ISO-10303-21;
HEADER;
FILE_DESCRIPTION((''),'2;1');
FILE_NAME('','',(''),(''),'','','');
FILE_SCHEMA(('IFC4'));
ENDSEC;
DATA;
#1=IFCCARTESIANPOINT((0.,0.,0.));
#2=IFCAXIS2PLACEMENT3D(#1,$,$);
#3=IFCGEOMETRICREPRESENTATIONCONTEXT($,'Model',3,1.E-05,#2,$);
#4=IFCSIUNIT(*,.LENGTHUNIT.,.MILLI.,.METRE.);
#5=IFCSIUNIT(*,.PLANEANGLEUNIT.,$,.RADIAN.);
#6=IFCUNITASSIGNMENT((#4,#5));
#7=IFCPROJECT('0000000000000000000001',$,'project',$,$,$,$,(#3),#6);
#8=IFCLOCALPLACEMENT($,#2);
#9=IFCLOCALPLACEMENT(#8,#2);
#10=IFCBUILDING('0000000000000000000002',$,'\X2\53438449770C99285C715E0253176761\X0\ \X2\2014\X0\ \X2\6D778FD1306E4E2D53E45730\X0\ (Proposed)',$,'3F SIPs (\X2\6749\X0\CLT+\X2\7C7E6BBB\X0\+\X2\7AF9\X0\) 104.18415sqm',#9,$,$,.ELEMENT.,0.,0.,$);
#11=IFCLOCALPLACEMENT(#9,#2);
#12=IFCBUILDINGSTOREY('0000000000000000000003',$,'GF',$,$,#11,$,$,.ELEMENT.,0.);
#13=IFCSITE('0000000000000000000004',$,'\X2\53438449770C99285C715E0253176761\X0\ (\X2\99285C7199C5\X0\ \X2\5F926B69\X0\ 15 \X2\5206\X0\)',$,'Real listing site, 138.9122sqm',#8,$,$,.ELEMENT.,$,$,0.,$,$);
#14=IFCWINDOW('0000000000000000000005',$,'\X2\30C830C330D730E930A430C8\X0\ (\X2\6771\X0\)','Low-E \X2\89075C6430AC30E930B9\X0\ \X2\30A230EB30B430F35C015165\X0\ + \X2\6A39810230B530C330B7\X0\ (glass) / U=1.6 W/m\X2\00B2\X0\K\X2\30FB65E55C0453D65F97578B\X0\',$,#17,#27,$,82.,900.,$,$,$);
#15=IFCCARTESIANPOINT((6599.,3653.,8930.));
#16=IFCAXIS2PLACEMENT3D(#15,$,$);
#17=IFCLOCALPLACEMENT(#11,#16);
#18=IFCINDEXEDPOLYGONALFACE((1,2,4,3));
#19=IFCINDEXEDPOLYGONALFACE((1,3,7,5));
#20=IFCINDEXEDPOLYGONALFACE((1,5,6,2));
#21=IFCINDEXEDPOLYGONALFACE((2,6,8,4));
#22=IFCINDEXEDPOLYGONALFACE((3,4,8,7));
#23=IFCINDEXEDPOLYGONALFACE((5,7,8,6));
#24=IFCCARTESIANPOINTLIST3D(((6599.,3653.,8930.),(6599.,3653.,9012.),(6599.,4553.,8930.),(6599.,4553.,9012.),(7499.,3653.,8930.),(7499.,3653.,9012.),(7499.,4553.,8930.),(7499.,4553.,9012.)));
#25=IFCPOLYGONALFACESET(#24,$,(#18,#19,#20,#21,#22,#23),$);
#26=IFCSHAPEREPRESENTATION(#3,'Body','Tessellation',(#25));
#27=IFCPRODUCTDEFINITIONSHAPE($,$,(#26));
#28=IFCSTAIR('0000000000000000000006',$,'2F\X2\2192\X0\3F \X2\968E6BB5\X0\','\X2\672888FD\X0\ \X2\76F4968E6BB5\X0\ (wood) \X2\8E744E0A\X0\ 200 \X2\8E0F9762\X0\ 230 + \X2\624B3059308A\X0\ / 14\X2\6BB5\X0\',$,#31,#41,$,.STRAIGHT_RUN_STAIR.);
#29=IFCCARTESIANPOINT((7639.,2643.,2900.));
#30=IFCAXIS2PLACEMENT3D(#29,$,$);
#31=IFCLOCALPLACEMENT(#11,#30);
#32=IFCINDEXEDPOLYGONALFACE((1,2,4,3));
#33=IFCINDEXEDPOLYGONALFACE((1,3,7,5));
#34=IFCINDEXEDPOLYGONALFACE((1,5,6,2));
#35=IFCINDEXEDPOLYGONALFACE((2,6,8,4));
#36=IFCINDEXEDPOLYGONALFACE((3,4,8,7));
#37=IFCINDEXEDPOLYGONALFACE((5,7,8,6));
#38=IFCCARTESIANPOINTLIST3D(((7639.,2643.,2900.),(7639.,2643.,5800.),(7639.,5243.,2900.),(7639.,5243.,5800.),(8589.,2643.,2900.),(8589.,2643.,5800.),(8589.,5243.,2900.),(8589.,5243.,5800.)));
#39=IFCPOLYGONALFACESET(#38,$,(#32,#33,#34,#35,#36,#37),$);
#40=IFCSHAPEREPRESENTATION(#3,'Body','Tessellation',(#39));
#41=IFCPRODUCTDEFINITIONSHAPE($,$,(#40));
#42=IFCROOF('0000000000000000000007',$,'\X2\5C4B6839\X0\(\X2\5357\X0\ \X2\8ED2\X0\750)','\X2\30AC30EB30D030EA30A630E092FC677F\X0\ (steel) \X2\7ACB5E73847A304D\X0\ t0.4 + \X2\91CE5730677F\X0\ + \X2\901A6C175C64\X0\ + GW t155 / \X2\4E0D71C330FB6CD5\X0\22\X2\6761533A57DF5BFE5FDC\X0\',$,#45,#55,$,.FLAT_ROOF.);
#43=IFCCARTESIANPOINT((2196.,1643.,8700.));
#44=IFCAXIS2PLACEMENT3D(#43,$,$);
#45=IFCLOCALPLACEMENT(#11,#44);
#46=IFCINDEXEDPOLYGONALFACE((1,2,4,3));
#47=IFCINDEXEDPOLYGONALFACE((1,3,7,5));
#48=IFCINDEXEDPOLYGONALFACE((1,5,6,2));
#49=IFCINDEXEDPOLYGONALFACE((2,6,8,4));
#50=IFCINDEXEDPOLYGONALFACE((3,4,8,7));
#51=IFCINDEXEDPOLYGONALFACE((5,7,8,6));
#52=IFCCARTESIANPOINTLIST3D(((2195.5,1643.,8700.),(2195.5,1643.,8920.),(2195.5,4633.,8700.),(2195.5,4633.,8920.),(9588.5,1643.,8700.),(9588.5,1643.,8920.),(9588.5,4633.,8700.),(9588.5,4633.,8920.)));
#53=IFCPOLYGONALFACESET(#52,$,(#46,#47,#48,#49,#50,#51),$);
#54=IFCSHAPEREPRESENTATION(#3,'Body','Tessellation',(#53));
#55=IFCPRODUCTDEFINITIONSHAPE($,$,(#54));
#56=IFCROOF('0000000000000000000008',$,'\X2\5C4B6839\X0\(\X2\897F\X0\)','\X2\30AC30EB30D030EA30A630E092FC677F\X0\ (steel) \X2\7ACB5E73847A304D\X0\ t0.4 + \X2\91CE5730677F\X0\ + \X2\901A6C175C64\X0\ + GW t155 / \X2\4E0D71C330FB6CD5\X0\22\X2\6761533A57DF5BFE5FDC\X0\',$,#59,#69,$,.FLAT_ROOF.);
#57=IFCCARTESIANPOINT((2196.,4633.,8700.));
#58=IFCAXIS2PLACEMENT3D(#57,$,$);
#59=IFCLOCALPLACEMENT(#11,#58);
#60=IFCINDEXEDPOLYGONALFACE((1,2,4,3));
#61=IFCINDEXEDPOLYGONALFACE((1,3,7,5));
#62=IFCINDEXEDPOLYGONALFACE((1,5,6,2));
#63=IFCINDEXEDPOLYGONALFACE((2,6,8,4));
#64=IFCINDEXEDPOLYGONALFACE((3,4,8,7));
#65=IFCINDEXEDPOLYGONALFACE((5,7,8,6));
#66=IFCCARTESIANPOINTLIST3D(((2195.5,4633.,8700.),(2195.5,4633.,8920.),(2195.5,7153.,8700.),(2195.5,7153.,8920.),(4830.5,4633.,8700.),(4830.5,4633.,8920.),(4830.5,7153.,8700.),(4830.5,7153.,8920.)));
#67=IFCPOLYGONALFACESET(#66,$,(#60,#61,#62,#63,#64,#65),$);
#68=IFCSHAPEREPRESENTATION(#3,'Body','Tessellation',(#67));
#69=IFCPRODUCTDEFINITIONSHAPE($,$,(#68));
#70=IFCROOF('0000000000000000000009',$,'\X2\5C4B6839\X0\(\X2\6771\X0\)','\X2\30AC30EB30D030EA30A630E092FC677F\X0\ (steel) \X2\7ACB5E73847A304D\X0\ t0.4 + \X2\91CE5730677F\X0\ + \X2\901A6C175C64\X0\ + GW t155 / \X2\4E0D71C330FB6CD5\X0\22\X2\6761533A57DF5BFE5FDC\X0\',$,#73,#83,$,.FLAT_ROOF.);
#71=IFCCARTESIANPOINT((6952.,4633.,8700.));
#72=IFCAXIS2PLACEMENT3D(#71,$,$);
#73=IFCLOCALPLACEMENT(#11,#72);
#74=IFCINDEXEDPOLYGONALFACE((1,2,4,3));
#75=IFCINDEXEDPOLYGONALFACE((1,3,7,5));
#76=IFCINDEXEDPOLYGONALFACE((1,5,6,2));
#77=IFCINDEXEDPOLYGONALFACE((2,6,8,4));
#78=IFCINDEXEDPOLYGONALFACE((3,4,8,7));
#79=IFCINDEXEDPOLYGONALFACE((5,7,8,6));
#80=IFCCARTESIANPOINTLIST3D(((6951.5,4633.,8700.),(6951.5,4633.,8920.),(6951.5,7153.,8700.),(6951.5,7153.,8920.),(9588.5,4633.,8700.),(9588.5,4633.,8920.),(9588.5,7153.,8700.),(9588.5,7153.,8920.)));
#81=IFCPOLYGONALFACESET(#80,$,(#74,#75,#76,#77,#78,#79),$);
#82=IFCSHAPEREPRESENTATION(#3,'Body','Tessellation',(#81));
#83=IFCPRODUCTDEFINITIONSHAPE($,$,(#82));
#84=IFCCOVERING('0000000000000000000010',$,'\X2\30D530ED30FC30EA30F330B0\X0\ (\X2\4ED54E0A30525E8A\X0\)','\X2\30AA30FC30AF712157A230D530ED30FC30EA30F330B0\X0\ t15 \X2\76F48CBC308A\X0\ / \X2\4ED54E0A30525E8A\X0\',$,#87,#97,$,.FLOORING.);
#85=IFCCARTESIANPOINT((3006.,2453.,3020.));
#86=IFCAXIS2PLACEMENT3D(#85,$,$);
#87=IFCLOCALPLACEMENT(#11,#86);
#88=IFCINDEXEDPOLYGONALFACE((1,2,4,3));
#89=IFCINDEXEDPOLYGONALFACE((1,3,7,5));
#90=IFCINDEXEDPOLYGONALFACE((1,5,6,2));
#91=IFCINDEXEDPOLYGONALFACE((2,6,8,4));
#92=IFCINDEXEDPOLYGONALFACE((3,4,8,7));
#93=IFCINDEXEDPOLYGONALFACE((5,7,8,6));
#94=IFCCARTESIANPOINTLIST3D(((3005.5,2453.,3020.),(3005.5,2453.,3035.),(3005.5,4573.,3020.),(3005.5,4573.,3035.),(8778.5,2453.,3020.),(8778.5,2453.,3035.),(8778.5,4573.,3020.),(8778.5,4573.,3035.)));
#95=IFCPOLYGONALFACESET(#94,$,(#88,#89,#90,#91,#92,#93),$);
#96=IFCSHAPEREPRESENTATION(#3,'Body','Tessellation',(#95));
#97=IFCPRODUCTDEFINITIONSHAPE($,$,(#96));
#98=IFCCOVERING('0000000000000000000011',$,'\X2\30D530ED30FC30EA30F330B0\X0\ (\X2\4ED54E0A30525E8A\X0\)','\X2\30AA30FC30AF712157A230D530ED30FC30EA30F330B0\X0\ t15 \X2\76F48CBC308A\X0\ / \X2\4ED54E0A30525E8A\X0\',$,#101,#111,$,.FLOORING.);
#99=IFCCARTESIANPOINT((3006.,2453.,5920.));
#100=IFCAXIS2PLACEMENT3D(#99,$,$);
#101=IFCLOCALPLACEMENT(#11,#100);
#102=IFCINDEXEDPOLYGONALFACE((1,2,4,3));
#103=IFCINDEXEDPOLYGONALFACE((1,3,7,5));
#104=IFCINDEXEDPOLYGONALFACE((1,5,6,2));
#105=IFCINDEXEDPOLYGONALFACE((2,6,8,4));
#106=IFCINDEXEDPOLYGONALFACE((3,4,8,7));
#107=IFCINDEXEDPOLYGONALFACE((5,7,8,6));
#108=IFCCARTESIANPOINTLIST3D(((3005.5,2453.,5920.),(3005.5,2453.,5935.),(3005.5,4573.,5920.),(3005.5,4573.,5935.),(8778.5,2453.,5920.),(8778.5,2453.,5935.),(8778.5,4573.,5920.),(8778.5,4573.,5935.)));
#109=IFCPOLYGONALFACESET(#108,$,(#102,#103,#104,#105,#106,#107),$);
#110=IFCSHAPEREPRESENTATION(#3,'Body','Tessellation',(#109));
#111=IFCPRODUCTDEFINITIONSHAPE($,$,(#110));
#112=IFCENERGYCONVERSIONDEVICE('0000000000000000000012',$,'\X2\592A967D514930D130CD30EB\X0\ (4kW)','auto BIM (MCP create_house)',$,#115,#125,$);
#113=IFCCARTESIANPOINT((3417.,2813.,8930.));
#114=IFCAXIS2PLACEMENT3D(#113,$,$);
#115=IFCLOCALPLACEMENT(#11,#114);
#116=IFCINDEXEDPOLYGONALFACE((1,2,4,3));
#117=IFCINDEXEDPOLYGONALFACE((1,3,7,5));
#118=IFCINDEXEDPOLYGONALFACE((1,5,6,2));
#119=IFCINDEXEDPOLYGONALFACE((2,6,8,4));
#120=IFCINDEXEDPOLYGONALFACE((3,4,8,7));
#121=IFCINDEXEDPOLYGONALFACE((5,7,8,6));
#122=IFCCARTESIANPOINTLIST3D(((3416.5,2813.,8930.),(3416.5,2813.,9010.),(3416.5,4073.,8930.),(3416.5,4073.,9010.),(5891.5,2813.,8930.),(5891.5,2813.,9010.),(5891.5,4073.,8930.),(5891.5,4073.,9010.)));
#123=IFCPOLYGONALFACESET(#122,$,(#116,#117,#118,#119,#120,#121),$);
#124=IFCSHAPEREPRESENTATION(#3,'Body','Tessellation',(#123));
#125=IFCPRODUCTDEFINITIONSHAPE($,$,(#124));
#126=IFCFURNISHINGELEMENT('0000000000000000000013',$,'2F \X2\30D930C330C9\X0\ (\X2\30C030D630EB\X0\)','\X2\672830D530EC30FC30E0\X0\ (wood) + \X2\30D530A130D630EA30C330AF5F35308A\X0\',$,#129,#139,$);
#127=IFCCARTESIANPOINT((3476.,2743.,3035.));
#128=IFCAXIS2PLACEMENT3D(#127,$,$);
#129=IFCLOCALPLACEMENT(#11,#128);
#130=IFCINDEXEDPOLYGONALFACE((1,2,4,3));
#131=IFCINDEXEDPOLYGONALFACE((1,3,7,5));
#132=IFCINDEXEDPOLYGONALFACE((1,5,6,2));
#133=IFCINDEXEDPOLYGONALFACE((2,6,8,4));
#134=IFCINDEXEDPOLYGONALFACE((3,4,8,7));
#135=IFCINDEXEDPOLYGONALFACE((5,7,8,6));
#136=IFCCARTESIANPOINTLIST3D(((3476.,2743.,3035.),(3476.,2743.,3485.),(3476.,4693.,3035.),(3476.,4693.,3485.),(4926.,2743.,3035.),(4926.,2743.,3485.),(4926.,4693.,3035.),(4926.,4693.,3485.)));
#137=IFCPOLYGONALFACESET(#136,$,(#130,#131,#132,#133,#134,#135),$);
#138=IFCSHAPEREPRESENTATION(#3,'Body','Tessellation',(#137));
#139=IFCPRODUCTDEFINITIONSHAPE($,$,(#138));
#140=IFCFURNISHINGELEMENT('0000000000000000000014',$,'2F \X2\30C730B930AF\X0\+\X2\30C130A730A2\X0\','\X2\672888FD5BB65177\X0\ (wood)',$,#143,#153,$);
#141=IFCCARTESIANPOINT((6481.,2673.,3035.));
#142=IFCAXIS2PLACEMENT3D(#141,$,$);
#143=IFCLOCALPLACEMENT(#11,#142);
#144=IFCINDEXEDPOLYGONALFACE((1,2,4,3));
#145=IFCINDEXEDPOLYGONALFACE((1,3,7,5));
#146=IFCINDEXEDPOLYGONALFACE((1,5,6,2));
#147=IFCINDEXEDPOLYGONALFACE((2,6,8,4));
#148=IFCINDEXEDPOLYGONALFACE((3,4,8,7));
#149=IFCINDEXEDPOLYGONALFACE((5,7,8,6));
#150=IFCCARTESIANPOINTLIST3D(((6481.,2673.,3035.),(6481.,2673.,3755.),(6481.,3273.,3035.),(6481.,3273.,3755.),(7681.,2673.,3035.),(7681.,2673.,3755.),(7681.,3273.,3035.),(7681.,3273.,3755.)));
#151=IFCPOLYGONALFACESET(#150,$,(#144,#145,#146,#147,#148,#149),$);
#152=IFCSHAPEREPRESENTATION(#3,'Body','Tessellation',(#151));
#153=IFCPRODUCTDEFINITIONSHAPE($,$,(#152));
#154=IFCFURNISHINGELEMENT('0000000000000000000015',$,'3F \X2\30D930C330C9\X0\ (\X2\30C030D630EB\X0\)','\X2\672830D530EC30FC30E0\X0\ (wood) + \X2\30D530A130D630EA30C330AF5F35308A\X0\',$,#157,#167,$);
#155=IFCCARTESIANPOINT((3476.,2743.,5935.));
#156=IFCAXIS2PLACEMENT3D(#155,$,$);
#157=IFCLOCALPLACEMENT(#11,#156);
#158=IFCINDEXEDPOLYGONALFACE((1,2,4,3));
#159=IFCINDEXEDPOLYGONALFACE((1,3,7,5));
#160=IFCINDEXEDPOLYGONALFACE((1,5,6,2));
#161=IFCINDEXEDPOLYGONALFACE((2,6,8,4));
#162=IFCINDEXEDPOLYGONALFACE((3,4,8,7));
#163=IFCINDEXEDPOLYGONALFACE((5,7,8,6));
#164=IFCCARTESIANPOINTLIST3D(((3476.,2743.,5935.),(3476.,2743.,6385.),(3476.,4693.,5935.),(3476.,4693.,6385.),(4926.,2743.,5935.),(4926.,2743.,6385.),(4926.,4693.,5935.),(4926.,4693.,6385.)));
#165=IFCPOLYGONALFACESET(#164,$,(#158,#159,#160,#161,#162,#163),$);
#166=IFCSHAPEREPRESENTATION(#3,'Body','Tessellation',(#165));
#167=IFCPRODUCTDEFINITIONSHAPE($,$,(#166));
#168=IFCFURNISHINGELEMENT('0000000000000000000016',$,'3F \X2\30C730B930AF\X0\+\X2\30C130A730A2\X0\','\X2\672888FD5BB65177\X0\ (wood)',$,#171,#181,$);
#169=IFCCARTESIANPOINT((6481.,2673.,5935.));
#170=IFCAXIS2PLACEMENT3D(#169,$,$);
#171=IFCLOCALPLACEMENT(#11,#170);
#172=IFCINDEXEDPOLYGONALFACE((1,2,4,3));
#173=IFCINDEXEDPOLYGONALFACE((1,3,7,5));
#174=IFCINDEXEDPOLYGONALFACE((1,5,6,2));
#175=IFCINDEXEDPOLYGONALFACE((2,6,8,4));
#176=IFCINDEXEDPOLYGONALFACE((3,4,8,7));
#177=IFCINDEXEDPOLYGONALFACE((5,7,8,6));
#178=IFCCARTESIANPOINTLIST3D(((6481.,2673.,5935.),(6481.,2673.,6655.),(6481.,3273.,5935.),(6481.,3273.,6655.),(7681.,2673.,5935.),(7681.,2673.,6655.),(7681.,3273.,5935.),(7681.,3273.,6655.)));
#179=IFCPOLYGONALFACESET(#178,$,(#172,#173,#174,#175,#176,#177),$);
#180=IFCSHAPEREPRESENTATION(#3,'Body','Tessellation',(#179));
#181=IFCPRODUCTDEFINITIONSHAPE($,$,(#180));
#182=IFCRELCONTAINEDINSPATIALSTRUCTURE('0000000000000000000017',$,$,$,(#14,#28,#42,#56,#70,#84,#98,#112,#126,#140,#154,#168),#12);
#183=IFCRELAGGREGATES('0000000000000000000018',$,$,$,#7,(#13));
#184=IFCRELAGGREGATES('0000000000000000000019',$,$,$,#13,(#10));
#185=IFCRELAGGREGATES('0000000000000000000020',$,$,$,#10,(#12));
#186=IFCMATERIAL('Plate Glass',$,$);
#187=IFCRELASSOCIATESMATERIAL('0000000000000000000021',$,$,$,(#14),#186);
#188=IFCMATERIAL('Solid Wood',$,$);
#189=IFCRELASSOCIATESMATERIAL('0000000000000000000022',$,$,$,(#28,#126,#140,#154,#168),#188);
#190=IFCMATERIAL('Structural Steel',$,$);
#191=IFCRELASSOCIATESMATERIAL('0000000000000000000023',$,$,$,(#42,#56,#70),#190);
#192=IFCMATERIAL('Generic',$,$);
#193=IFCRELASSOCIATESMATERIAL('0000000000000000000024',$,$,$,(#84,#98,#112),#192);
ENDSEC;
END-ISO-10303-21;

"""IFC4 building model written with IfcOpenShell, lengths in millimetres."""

from ifc_helpers import new_model, si_unit, frame, frame_2d, origin, place, context, project, spatial, rectangle, extrude, material, element, save


model = new_model("IFC4")

# Units and contexts
model_context = context("Model", 3, precision=1e-05, world=origin())
ifc_project = project(units=[si_unit("LENGTHUNIT", "METRE", prefix="MILLI"), si_unit("PLANEANGLEUNIT", "RADIAN")], contexts=[model_context])

# Site, building, storey
site_placement = place(None, origin())
site = spatial("IfcSite", under=ifc_project, at=site_placement, Name="千葉県館山市北条 (館山駅 徒歩 15 分)", ObjectType="Real listing site, 138.9122sqm", CompositionType="ELEMENT", RefElevation=0.0)
building_placement = place(site_placement, origin())
building = spatial("IfcBuilding", under=site, at=building_placement, Name="千葉県館山市北条 — 海近の中古地 (Proposed)", ObjectType="3F SIPs (杉CLT+籾殻+竹) 104.18415sqm", CompositionType="ELEMENT", ElevationOfRefHeight=0.0, ElevationOfTerrain=0.0)
storey_placement = place(building_placement, origin())
storey = spatial("IfcBuildingStorey", under=building, at=storey_placement, Name="GF", CompositionType="ELEMENT", Elevation=0.0)

# Shared definitions
ifc_material_1 = material(Name="Solid Wood")

# Shared definitions
ifc_material_2 = material(Name="Plate Glass")

# Window
window_1_placement = place(storey_placement, frame((6599.0, 3653.0, 8930.0)))
element("IfcWindow", 1, at=window_1_placement, inside=storey, material=ifc_material_2, Name="トップライト (東)", Description="Low-E 複層ガラス アルゴン封入 + 樹脂サッシ (glass) / U=1.6 W/m²K・日射取得型", OverallHeight=82.0, OverallWidth=900.0, context=model_context, shape_type="SweptSolid", body=[
    extrude(rectangle(XDim=900.0, YDim=900.0, at=frame_2d((450.0, 450.0))), frame((6599.0, 3653.0, 8930.0)), (0.0, 0.0, 1.0), 82.0),
])

# Stair
stair_placement = place(storey_placement, frame((7639.0, 2643.0, 2900.0)))
element("IfcStair", 2, at=stair_placement, inside=storey, material=ifc_material_1, Name="2F→3F 階段", Description="木製 直階段 (wood) 蹴上 200 踏面 230 + 手すり / 14段", PredefinedType="STRAIGHT_RUN_STAIR", context=model_context, shape_type="SweptSolid", body=[
    extrude(rectangle(XDim=950.0, YDim=2600.0, at=frame_2d((475.0, 1300.0))), frame((7639.0, 2643.0, 2900.0)), (0.0, 0.0, 1.0), 2900.0),
])

# Roofs
ifc_material_3 = material(Name="Structural Steel")
roof_1_placement = place(storey_placement, frame((2196.0, 1643.0, 8700.0)))
element("IfcRoof", 3, at=roof_1_placement, inside=storey, material=ifc_material_3, Name="屋根(南 軒750)", Description="ガルバリウム鋼板 (steel) 立平葺き t0.4 + 野地板 + 通気層 + GW t155 / 不燃・法22条区域対応", PredefinedType="FLAT_ROOF", context=model_context, shape_type="SweptSolid", body=[
    extrude(rectangle(XDim=7393.0, YDim=2990.0, at=frame_2d((3696.0, 1495.0))), frame((2196.0, 1643.0, 8700.0)), (0.0, 0.0, 1.0), 220.0),
])
roof_2_placement = place(storey_placement, frame((2196.0, 4633.0, 8700.0)))
element("IfcRoof", 4, at=roof_2_placement, inside=storey, material=ifc_material_3, Name="屋根(西)", Description="ガルバリウム鋼板 (steel) 立平葺き t0.4 + 野地板 + 通気層 + GW t155 / 不燃・法22条区域対応", PredefinedType="FLAT_ROOF", context=model_context, shape_type="SweptSolid", body=[
    extrude(rectangle(XDim=2635.0, YDim=2520.0, at=frame_2d((1317.0, 1260.0))), frame((2196.0, 4633.0, 8700.0)), (0.0, 0.0, 1.0), 220.0),
])
roof_3_placement = place(storey_placement, frame((6952.0, 4633.0, 8700.0)))
element("IfcRoof", 5, at=roof_3_placement, inside=storey, material=ifc_material_3, Name="屋根(東)", Description="ガルバリウム鋼板 (steel) 立平葺き t0.4 + 野地板 + 通気層 + GW t155 / 不燃・法22条区域対応", PredefinedType="FLAT_ROOF", context=model_context, shape_type="SweptSolid", body=[
    extrude(rectangle(XDim=2637.0, YDim=2520.0, at=frame_2d((1318.0, 1260.0))), frame((6952.0, 4633.0, 8700.0)), (0.0, 0.0, 1.0), 220.0),
])

# Coverings
ifc_material_4 = material(Name="Generic")
covering_1_placement = place(storey_placement, frame((3006.0, 2453.0, 3020.0)))
element("IfcCovering", 6, at=covering_1_placement, inside=storey, material=ifc_material_4, Name="フローリング (仕上げ床)", Description="オーク無垢フローリング t15 直貼り / 仕上げ床", PredefinedType="FLOORING", context=model_context, shape_type="SweptSolid", body=[
    extrude(rectangle(XDim=5773.0, YDim=2120.0, at=frame_2d((2886.0, 1060.0))), frame((3006.0, 2453.0, 3020.0)), (0.0, 0.0, 1.0), 15.0),
])
covering_2_placement = place(storey_placement, frame((3006.0, 2453.0, 5920.0)))
element("IfcCovering", 7, at=covering_2_placement, inside=storey, material=ifc_material_4, Name="フローリング (仕上げ床)", Description="オーク無垢フローリング t15 直貼り / 仕上げ床", PredefinedType="FLOORING", context=model_context, shape_type="SweptSolid", body=[
    extrude(rectangle(XDim=5773.0, YDim=2120.0, at=frame_2d((2886.0, 1060.0))), frame((3006.0, 2453.0, 5920.0)), (0.0, 0.0, 1.0), 15.0),
])

# Energy conversion device
energy_conversion_device_placement = place(storey_placement, frame((3417.0, 2813.0, 8930.0)))
element("IfcEnergyConversionDevice", 8, at=energy_conversion_device_placement, inside=storey, material=ifc_material_4, Name="太陽光パネル (4kW)", Description="auto BIM (MCP create_house)", context=model_context, shape_type="SweptSolid", body=[
    extrude(rectangle(XDim=2475.0, YDim=1260.0, at=frame_2d((1237.0, 630.0))), frame((3417.0, 2813.0, 8930.0)), (0.0, 0.0, 1.0), 80.0),
])

# Furnishing elements
furnishing_1_placement = place(storey_placement, frame((3476.0, 2743.0, 3035.0)))
element("IfcFurnishingElement", 9, at=furnishing_1_placement, inside=storey, material=ifc_material_1, Name="2F ベッド (ダブル)", Description="木フレーム (wood) + ファブリック張り", context=model_context, shape_type="SweptSolid", body=[
    extrude(rectangle(XDim=1450.0, YDim=1950.0, at=frame_2d((725.0, 975.0))), frame((3476.0, 2743.0, 3035.0)), (0.0, 0.0, 1.0), 450.0),
])
furnishing_2_placement = place(storey_placement, frame((6481.0, 2673.0, 3035.0)))
element("IfcFurnishingElement", 10, at=furnishing_2_placement, inside=storey, material=ifc_material_1, Name="2F デスク+チェア", Description="木製家具 (wood)", context=model_context, shape_type="SweptSolid", body=[
    extrude(rectangle(XDim=1200.0, YDim=600.0, at=frame_2d((600.0, 300.0))), frame((6481.0, 2673.0, 3035.0)), (0.0, 0.0, 1.0), 720.0),
])
furnishing_3_placement = place(storey_placement, frame((3476.0, 2743.0, 5935.0)))
element("IfcFurnishingElement", 11, at=furnishing_3_placement, inside=storey, material=ifc_material_1, Name="3F ベッド (ダブル)", Description="木フレーム (wood) + ファブリック張り", context=model_context, shape_type="SweptSolid", body=[
    extrude(rectangle(XDim=1450.0, YDim=1950.0, at=frame_2d((725.0, 975.0))), frame((3476.0, 2743.0, 5935.0)), (0.0, 0.0, 1.0), 450.0),
])
furnishing_4_placement = place(storey_placement, frame((6481.0, 2673.0, 5935.0)))
element("IfcFurnishingElement", 12, at=furnishing_4_placement, inside=storey, material=ifc_material_1, Name="3F デスク+チェア", Description="木製家具 (wood)", context=model_context, shape_type="SweptSolid", body=[
    extrude(rectangle(XDim=1200.0, YDim=600.0, at=frame_2d((600.0, 300.0))), frame((6481.0, 2673.0, 5935.0)), (0.0, 0.0, 1.0), 720.0),
])

save(model, "model.ifc")
